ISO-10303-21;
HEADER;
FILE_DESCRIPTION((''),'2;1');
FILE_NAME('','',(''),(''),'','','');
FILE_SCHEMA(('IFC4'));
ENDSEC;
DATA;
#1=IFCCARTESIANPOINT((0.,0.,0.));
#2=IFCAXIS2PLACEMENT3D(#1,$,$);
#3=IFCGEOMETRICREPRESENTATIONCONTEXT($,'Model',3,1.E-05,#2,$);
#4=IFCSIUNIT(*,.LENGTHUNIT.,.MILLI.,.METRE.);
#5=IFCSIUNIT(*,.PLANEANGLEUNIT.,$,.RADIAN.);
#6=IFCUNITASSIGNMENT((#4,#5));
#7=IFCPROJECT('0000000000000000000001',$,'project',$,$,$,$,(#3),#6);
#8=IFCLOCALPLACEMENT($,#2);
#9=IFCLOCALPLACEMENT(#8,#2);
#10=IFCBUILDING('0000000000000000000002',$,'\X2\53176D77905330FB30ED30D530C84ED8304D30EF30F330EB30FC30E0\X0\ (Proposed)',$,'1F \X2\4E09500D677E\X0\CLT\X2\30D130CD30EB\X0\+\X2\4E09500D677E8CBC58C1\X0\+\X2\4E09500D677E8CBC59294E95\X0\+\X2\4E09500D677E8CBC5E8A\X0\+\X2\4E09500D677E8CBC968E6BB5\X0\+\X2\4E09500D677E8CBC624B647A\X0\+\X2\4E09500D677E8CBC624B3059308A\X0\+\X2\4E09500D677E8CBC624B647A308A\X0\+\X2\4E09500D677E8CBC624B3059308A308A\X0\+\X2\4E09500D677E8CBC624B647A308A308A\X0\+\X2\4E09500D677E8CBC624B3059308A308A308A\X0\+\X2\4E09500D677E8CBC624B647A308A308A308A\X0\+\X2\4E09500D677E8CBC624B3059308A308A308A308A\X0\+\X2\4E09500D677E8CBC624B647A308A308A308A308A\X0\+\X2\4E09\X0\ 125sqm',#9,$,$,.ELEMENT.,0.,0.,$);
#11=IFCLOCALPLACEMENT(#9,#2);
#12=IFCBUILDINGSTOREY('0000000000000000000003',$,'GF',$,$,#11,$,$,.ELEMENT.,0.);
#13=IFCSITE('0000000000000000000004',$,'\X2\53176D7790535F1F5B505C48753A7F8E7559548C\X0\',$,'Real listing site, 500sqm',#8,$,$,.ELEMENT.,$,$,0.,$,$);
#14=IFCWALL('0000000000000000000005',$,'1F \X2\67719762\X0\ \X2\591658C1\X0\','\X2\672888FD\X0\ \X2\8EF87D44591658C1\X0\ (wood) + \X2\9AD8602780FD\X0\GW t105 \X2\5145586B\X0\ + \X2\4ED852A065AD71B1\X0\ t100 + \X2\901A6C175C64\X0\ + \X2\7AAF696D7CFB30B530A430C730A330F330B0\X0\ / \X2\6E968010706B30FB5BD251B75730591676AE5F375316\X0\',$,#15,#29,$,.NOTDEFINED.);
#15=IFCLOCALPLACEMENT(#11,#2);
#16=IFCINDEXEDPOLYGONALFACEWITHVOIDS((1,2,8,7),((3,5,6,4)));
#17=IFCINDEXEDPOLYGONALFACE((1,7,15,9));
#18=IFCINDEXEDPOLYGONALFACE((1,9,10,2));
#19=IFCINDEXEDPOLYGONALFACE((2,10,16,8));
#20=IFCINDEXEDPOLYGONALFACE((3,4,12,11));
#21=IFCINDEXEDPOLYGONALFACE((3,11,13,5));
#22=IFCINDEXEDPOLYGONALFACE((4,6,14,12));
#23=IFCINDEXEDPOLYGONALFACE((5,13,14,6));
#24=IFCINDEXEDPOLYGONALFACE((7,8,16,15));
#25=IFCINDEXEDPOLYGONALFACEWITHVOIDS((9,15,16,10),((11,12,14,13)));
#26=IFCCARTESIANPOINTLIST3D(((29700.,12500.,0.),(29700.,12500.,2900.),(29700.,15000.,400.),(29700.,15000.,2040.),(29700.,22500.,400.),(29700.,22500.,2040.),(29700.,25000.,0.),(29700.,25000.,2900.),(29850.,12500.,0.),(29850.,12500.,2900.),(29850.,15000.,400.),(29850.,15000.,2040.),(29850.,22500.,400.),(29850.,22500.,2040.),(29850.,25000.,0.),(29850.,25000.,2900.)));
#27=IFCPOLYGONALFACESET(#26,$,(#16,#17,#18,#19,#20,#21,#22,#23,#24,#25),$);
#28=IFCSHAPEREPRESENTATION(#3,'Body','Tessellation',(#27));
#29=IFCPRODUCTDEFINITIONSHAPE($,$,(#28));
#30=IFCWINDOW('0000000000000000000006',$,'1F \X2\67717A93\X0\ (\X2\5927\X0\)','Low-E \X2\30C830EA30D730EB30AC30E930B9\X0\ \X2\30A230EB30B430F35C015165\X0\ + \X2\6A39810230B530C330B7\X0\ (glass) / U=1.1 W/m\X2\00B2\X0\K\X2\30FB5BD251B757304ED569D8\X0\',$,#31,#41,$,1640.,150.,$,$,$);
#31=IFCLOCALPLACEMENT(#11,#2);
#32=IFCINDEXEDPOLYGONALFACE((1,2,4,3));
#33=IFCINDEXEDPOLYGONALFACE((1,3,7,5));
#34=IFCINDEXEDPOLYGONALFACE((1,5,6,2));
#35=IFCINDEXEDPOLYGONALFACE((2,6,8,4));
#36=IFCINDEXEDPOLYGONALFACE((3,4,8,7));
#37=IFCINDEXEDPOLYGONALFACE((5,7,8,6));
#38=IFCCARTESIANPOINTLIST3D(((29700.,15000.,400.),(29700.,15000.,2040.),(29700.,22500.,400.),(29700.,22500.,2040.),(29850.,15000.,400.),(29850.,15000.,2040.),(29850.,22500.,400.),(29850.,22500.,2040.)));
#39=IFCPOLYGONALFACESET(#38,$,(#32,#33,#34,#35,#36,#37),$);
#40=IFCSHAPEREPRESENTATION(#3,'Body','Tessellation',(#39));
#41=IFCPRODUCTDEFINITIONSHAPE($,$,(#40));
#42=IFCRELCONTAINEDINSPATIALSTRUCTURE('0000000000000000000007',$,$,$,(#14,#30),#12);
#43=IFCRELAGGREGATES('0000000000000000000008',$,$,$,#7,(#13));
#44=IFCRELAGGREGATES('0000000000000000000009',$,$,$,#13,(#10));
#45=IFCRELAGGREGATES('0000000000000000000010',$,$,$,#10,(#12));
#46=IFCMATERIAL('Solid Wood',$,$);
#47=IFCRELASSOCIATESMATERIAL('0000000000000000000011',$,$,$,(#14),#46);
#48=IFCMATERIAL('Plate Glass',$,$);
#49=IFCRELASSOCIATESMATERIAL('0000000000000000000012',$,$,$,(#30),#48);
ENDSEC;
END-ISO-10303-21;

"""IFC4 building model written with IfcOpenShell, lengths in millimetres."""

from ifc_helpers import new_model, si_unit, frame, frame_2d, origin, place, context, project, spatial, rectangle, extrude, material, element, fill, save


model = new_model("IFC4")

# Units and contexts
model_context = context("Model", 3, precision=1e-05, world=origin())
ifc_project = project(units=[si_unit("LENGTHUNIT", "METRE", prefix="MILLI"), si_unit("PLANEANGLEUNIT", "RADIAN")], contexts=[model_context])

# Site, building, storey
site_placement = place(None, origin())
site = spatial("IfcSite", under=ifc_project, at=site_placement, Name="北海道弟子屈町美留和", ObjectType="Real listing site, 500sqm", CompositionType="ELEMENT", RefElevation=0.0)
building_placement = place(site_placement, origin())
building = spatial("IfcBuilding", under=site, at=building_placement, Name="北海道・ロフト付きワンルーム (Proposed)", ObjectType="1F 三倍松CLTパネル+三倍松貼壁+三倍松貼天井+三倍松貼床+三倍松貼階段+三倍松貼手摺+三倍松貼手すり+三倍松貼手摺り+三倍松貼手すりり+三倍松貼手摺りり+三倍松貼手すりりり+三倍松貼手摺りりり+三倍松貼手すりりりり+三倍松貼手摺りりりり+三 125sqm", CompositionType="ELEMENT", ElevationOfRefHeight=0.0, ElevationOfTerrain=0.0)
storey_placement = place(building_placement, origin())
storey = spatial("IfcBuildingStorey", under=building, at=storey_placement, Name="GF", CompositionType="ELEMENT", Elevation=0.0)

# Shared definitions
ifc_material_1 = material(Name="Solid Wood")

# Wall, opening, window
wall_1_placement = place(storey_placement, frame((14850.0, 6250.0, 0.0)))
wall_1 = element("IfcWall", 1, at=wall_1_placement, inside=storey, material=ifc_material_1, Name="1F 東面 外壁", Description="木製 軸組外壁 (wood) + 高性能GW t105 充填 + 付加断熱 t100 + 通気層 + 窯業系サイディング / 準耐火・寒冷地外皮強化", PredefinedType="NOTDEFINED", context=model_context, shape_type="SweptSolid", body=[
    extrude(rectangle(XDim=150.0, YDim=12500.0, at=frame_2d((75.0, 6250.0))), frame((14850.0, 6250.0, 0.0)), (0.0, 0.0, 1.0), 2900.0),
])
opening_placement = place(storey_placement, frame((14850.0, 7500.0, 200.0)))
opening = element("IfcOpeningElement", 2, at=opening_placement, cuts=wall_1, PredefinedType="NOTDEFINED", context=model_context, shape_type="SweptSolid", body=[
    extrude(rectangle(XDim=150.0, YDim=7500.0, at=frame_2d((75.0, 3750.0))), frame((14850.0, 7500.0, 200.0)), (0.0, 0.0, 1.0), 1640.0),
])
ifc_material_2 = material(Name="Plate Glass")
window_placement = place(storey_placement, frame((14850.0, 7500.0, 200.0)))
window = element("IfcWindow", 3, at=window_placement, inside=storey, material=ifc_material_2, Name="1F 東窓 (大)", Description="Low-E トリプルガラス アルゴン封入 + 樹脂サッシ (glass) / U=1.1 W/m²K・寒冷地仕様", OverallHeight=1640.0, OverallWidth=150.0, context=model_context, shape_type="SweptSolid", body=[
    extrude(rectangle(XDim=150.0, YDim=7500.0, at=frame_2d((75.0, 3750.0))), frame((14850.0, 7500.0, 200.0)), (0.0, 0.0, 1.0), 1640.0),
])
fill(opening, window)

save(model, "model.ifc")
